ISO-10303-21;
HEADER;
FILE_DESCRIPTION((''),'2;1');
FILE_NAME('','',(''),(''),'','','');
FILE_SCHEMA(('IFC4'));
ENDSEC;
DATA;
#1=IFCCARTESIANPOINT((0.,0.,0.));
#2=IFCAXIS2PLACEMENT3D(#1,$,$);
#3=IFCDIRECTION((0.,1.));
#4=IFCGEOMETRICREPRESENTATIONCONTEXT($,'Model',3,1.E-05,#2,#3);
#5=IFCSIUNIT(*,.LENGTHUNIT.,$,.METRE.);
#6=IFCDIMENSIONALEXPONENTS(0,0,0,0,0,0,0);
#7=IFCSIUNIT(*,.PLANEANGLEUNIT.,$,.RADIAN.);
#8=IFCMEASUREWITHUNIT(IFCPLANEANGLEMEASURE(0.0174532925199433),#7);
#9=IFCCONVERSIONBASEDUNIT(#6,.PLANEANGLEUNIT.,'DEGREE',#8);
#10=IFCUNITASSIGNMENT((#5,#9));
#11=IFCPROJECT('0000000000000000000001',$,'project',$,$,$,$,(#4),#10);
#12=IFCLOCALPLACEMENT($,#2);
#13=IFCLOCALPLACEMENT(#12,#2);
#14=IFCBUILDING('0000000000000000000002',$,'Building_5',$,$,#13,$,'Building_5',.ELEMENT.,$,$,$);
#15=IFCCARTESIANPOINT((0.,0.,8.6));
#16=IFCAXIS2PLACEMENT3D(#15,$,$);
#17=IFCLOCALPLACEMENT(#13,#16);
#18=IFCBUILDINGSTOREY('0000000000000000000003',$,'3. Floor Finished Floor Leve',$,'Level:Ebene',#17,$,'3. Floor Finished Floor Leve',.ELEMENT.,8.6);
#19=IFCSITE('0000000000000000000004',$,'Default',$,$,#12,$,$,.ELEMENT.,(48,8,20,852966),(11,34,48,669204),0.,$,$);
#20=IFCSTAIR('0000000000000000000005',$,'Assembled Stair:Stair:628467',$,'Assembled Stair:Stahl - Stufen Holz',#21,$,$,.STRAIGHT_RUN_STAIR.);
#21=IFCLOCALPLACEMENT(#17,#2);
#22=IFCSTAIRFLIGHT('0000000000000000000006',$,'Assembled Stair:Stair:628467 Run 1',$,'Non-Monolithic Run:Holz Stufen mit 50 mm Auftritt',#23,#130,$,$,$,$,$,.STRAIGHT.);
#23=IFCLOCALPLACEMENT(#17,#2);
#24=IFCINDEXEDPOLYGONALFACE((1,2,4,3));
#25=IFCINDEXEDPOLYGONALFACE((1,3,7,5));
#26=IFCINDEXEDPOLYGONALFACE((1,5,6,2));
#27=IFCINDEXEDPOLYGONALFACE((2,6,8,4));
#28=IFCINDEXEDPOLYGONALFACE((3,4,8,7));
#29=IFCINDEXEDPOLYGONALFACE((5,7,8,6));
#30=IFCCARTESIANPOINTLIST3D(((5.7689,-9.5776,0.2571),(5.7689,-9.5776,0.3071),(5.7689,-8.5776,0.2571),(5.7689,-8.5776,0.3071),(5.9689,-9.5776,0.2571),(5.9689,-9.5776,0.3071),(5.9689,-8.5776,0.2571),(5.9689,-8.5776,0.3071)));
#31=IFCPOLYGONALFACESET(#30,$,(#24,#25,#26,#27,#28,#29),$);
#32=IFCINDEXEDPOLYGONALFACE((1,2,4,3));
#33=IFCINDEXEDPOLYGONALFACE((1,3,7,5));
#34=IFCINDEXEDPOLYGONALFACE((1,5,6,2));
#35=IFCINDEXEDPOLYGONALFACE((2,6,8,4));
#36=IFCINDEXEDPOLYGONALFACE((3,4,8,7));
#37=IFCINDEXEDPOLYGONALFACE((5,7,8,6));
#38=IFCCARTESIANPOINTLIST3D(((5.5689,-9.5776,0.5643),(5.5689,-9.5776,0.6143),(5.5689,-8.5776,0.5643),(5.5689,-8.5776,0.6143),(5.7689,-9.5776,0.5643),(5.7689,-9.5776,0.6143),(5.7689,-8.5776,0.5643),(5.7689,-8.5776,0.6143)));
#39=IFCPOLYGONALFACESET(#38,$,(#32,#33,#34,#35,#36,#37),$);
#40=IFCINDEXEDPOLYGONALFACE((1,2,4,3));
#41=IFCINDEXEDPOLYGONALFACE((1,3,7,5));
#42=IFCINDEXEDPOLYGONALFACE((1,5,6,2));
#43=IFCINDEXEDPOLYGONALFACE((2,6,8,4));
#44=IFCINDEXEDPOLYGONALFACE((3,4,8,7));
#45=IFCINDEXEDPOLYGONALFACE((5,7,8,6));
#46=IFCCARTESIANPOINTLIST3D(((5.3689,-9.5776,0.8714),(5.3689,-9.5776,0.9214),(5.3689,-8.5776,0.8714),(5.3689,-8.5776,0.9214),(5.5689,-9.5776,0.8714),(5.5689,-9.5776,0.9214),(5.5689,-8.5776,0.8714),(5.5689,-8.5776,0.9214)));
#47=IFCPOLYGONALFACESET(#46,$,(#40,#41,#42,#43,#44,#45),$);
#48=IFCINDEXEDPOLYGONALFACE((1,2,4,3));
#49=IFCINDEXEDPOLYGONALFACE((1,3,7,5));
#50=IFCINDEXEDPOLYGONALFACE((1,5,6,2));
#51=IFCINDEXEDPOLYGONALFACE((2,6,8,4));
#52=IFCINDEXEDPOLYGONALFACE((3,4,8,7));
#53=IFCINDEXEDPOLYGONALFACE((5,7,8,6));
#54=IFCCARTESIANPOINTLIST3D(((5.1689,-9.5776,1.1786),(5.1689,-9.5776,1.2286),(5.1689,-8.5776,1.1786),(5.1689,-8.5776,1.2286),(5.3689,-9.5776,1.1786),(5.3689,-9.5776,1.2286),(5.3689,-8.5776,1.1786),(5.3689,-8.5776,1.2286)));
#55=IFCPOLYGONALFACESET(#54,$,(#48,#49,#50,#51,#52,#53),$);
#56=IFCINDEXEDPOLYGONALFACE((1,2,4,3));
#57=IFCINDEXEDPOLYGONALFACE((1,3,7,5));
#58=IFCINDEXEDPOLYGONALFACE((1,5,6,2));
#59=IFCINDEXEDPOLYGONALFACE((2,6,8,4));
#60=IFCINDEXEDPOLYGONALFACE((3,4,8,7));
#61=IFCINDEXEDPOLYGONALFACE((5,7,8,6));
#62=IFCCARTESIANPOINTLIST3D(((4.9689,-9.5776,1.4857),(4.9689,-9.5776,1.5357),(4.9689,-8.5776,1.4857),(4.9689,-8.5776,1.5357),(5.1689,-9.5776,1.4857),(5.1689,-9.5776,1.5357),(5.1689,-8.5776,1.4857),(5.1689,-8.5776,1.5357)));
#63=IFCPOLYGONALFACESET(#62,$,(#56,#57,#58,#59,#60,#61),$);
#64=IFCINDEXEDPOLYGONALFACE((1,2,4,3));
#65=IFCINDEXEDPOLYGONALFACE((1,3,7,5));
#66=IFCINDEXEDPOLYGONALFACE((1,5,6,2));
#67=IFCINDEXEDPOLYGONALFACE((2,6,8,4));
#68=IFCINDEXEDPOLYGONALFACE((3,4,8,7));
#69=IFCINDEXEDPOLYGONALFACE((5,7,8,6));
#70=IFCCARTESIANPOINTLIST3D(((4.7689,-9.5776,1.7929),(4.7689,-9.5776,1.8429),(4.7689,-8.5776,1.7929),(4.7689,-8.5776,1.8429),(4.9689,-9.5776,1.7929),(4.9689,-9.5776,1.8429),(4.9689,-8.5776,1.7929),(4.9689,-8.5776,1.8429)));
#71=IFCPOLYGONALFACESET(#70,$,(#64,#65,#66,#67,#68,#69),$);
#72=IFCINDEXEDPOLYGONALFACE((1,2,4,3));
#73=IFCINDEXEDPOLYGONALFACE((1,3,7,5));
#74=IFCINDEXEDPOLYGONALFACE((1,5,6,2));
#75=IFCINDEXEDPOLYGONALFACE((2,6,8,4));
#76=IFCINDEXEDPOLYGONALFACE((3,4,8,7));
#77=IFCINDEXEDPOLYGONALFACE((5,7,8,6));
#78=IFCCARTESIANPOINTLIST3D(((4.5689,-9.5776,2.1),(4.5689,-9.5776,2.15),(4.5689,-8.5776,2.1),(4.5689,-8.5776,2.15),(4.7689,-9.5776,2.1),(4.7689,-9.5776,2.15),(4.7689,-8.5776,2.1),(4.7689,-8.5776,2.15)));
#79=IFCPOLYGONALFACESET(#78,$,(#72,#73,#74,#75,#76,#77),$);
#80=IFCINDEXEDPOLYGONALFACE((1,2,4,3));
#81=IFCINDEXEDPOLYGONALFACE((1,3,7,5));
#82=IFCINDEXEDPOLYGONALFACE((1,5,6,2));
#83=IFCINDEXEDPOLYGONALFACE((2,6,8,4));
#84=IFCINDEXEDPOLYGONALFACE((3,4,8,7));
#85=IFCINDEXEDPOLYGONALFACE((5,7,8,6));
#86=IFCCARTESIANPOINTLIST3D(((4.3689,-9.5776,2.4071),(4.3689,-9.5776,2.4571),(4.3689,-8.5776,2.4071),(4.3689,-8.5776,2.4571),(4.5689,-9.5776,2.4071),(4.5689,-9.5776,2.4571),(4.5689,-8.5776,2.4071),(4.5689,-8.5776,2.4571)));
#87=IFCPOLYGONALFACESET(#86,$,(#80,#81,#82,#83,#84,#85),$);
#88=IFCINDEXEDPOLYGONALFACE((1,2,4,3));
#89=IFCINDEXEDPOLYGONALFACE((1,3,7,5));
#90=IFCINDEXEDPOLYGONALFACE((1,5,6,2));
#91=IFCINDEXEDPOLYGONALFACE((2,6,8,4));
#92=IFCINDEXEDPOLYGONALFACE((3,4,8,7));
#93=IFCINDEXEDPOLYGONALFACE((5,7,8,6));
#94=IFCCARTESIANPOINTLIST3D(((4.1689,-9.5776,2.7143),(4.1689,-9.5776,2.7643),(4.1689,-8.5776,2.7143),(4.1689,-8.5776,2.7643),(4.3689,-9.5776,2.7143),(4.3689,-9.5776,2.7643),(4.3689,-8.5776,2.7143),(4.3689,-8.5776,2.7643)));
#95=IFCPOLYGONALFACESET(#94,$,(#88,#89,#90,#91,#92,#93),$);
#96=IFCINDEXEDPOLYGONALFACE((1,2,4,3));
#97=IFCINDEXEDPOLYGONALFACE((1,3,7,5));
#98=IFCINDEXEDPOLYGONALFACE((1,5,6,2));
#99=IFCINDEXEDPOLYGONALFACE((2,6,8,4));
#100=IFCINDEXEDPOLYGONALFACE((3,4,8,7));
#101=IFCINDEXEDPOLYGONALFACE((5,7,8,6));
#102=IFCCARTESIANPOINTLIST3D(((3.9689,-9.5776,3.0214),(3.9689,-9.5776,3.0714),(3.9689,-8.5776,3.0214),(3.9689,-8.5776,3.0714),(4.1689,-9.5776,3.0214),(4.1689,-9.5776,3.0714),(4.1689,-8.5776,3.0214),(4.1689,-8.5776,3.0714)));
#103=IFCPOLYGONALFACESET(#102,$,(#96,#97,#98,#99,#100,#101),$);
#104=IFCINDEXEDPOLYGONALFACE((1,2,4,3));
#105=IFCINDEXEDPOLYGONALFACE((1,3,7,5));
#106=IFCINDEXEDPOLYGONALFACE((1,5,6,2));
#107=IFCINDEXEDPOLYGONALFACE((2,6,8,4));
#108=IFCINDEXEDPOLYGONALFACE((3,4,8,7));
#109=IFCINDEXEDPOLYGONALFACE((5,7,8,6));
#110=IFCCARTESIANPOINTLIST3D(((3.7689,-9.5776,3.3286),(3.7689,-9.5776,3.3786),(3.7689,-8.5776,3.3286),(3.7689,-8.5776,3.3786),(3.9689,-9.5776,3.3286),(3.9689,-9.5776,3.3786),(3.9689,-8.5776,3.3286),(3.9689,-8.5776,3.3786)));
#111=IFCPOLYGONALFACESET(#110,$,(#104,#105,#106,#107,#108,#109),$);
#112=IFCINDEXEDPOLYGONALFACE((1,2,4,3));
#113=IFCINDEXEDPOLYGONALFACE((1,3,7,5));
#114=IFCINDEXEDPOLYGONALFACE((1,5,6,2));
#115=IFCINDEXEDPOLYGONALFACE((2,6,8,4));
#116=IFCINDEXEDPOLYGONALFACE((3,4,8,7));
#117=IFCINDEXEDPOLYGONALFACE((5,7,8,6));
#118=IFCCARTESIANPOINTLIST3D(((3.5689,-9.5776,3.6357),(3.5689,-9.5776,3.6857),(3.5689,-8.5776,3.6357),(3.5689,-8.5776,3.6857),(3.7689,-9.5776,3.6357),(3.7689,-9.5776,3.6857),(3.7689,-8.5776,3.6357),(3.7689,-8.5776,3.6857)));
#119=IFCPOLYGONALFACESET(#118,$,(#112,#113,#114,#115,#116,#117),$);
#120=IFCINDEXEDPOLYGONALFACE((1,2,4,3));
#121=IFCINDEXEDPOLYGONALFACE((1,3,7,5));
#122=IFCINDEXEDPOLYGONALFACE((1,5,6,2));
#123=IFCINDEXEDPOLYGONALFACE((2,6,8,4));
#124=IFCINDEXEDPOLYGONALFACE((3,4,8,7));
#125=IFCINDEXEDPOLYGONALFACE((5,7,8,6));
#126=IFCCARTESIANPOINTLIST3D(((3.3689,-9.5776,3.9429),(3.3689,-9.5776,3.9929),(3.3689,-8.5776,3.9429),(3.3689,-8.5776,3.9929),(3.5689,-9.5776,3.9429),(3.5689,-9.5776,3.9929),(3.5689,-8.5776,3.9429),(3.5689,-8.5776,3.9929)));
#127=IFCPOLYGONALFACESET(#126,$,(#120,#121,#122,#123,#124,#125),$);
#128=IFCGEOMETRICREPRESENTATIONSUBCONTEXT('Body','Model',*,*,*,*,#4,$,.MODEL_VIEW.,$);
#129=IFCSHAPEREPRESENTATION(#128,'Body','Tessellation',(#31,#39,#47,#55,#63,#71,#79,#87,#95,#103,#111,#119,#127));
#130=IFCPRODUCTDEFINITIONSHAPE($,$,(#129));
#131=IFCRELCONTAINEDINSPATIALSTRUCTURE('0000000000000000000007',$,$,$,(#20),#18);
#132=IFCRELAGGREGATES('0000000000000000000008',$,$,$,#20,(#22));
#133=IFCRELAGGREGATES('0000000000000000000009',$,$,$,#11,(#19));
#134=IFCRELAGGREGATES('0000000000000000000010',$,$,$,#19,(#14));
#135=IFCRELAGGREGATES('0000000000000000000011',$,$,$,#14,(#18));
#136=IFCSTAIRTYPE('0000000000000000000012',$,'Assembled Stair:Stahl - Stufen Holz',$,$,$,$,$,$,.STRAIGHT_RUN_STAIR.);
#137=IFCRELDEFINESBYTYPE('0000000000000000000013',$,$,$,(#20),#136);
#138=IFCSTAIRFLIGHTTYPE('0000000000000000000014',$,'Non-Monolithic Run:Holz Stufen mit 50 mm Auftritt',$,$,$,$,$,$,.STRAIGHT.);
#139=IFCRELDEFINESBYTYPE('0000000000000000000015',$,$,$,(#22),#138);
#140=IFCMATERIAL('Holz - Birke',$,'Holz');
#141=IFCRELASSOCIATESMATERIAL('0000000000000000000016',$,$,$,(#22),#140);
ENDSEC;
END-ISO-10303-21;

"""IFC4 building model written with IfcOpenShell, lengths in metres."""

from ifc_helpers import new_model, entity, si_unit, converted_unit, direction, frame, origin, place, context, subcontext, project, spatial, indexed_curve, outline, extrude, material, type_object, element, aggregate, save


model = new_model("IFC4")

# Units and contexts
model_context = context("Model", 3, precision=1e-05, world=origin(), true_north=direction((0.0, 1.0)))
body_context = subcontext(model_context, "Body", "Model", "MODEL_VIEW")
ifc_project = project(units=[si_unit("LENGTHUNIT", "METRE"), converted_unit("PLANEANGLEUNIT", "DEGREE", entity("IfcPlaneAngleMeasure", 0.0174532925199433), si_unit("PLANEANGLEUNIT", "RADIAN"), dimensions=[0, 0, 0, 0, 0, 0, 0])], contexts=[model_context])

# Site, building, storey
site_placement = place(None, origin())
site = spatial("IfcSite", under=ifc_project, at=site_placement, Name="Default", CompositionType="ELEMENT", RefLatitude=(48, 8, 20, 852966), RefLongitude=(11, 34, 48, 669204), RefElevation=0.0)
building_placement = place(site_placement, origin())
building = spatial("IfcBuilding", under=site, at=building_placement, Name="Building_5", LongName="Building_5", CompositionType="ELEMENT")
storey_placement = place(building_placement, frame((0.0, 0.0, 8.6)))
storey = spatial("IfcBuildingStorey", under=building, at=storey_placement, Name="3. Floor Finished Floor Leve", ObjectType="Level:Ebene", LongName="3. Floor Finished Floor Leve", CompositionType="ELEMENT", Elevation=8.6)

# Stair, stair flight
stair_type_1 = type_object("IfcStairType", Name="Assembled Stair:Stahl - Stufen Holz", PredefinedType="STRAIGHT_RUN_STAIR")
stair_1_placement = place(storey_placement, origin())
stair_1 = element("IfcStair", 1, at=stair_1_placement, inside=storey, type_object=stair_type_1, Name="Assembled Stair:Stair:628467", ObjectType="Assembled Stair:Stahl - Stufen Holz", PredefinedType="STRAIGHT_RUN_STAIR")
ifc_material_1 = material(Name="Holz - Birke", Category="Holz")
stair_flight_type_1 = type_object("IfcStairFlightType", Name="Non-Monolithic Run:Holz Stufen mit 50 mm Auftritt", PredefinedType="STRAIGHT")
stair_flight_1_placement = place(stair_1_placement, origin())
stair_flight_1 = element("IfcStairFlight", 2, at=stair_flight_1_placement, type_object=stair_flight_type_1, material=ifc_material_1, Name="Assembled Stair:Stair:628467 Run 1", ObjectType="Non-Monolithic Run:Holz Stufen mit 50 mm Auftritt", PredefinedType="STRAIGHT", context=body_context, shape_type="SweptSolid", body=[
    extrude(outline(indexed_curve([(-0.1, -0.5), (0.1, -0.5), (0.1, 0.5), (-0.1, 0.5), (-0.1, -0.5)], self_intersect=False)), frame((5.8689, -9.0776, 0.2571)), (0.0, 0.0, 1.0), 0.05),
    extrude(outline(indexed_curve([(-0.1, -0.5), (0.1, -0.5), (0.1, 0.5), (-0.1, 0.5), (-0.1, -0.5)], self_intersect=False)), frame((5.6689, -9.0776, 0.5643)), (0.0, 0.0, 1.0), 0.05),
    extrude(outline(indexed_curve([(-0.1, -0.5), (0.1, -0.5), (0.1, 0.5), (-0.1, 0.5), (-0.1, -0.5)], self_intersect=False)), frame((5.4689, -9.0776, 0.8714)), (0.0, 0.0, 1.0), 0.05),
    extrude(outline(indexed_curve([(-0.1, -0.5), (0.1, -0.5), (0.1, 0.5), (-0.1, 0.5), (-0.1, -0.5)], self_intersect=False)), frame((5.2689, -9.0776, 1.1786)), (0.0, 0.0, 1.0), 0.05),
    extrude(outline(indexed_curve([(-0.1, -0.5), (0.1, -0.5), (0.1, 0.5), (-0.1, 0.5), (-0.1, -0.5)], self_intersect=False)), frame((5.0689, -9.0776, 1.4857)), (0.0, 0.0, 1.0), 0.05),
    extrude(outline(indexed_curve([(-0.1, -0.5), (0.1, -0.5), (0.1, 0.5), (-0.1, 0.5), (-0.1, -0.5)], self_intersect=False)), frame((4.8689, -9.0776, 1.7929)), (0.0, 0.0, 1.0), 0.05),
    extrude(outline(indexed_curve([(-0.1, -0.5), (0.1, -0.5), (0.1, 0.5), (-0.1, 0.5), (-0.1, -0.5)], self_intersect=False)), frame((4.6689, -9.0776, 2.1)), (0.0, 0.0, 1.0), 0.05),
    extrude(outline(indexed_curve([(-0.1, -0.5), (0.1, -0.5), (0.1, 0.5), (-0.1, 0.5), (-0.1, -0.5)], self_intersect=False)), frame((4.4689, -9.0776, 2.4071)), (0.0, 0.0, 1.0), 0.05),
    extrude(outline(indexed_curve([(-0.1, -0.5), (0.1, -0.5), (0.1, 0.5), (-0.1, 0.5), (-0.1, -0.5)], self_intersect=False)), frame((4.2689, -9.0776, 2.7143)), (0.0, 0.0, 1.0), 0.05),
    extrude(outline(indexed_curve([(-0.1, -0.5), (0.1, -0.5), (0.1, 0.5), (-0.1, 0.5), (-0.1, -0.5)], self_intersect=False)), frame((4.0689, -9.0776, 3.0214)), (0.0, 0.0, 1.0), 0.05),
    extrude(outline(indexed_curve([(-0.1, -0.5), (0.1, -0.5), (0.1, 0.5), (-0.1, 0.5), (-0.1, -0.5)], self_intersect=False)), frame((3.8689, -9.0776, 3.3286)), (0.0, 0.0, 1.0), 0.05),
    extrude(outline(indexed_curve([(-0.1, -0.5), (0.1, -0.5), (0.1, 0.5), (-0.1, 0.5), (-0.1, -0.5)], self_intersect=False)), frame((3.6689, -9.0776, 3.6357)), (0.0, 0.0, 1.0), 0.05),
    extrude(outline(indexed_curve([(-0.1, -0.5), (0.1, -0.5), (0.1, 0.5), (-0.1, 0.5), (-0.1, -0.5)], self_intersect=False)), frame((3.4689, -9.0776, 3.9429)), (0.0, 0.0, 1.0), 0.05),
])
aggregate(stair_1, [stair_flight_1])

save(model, "model.ifc")
